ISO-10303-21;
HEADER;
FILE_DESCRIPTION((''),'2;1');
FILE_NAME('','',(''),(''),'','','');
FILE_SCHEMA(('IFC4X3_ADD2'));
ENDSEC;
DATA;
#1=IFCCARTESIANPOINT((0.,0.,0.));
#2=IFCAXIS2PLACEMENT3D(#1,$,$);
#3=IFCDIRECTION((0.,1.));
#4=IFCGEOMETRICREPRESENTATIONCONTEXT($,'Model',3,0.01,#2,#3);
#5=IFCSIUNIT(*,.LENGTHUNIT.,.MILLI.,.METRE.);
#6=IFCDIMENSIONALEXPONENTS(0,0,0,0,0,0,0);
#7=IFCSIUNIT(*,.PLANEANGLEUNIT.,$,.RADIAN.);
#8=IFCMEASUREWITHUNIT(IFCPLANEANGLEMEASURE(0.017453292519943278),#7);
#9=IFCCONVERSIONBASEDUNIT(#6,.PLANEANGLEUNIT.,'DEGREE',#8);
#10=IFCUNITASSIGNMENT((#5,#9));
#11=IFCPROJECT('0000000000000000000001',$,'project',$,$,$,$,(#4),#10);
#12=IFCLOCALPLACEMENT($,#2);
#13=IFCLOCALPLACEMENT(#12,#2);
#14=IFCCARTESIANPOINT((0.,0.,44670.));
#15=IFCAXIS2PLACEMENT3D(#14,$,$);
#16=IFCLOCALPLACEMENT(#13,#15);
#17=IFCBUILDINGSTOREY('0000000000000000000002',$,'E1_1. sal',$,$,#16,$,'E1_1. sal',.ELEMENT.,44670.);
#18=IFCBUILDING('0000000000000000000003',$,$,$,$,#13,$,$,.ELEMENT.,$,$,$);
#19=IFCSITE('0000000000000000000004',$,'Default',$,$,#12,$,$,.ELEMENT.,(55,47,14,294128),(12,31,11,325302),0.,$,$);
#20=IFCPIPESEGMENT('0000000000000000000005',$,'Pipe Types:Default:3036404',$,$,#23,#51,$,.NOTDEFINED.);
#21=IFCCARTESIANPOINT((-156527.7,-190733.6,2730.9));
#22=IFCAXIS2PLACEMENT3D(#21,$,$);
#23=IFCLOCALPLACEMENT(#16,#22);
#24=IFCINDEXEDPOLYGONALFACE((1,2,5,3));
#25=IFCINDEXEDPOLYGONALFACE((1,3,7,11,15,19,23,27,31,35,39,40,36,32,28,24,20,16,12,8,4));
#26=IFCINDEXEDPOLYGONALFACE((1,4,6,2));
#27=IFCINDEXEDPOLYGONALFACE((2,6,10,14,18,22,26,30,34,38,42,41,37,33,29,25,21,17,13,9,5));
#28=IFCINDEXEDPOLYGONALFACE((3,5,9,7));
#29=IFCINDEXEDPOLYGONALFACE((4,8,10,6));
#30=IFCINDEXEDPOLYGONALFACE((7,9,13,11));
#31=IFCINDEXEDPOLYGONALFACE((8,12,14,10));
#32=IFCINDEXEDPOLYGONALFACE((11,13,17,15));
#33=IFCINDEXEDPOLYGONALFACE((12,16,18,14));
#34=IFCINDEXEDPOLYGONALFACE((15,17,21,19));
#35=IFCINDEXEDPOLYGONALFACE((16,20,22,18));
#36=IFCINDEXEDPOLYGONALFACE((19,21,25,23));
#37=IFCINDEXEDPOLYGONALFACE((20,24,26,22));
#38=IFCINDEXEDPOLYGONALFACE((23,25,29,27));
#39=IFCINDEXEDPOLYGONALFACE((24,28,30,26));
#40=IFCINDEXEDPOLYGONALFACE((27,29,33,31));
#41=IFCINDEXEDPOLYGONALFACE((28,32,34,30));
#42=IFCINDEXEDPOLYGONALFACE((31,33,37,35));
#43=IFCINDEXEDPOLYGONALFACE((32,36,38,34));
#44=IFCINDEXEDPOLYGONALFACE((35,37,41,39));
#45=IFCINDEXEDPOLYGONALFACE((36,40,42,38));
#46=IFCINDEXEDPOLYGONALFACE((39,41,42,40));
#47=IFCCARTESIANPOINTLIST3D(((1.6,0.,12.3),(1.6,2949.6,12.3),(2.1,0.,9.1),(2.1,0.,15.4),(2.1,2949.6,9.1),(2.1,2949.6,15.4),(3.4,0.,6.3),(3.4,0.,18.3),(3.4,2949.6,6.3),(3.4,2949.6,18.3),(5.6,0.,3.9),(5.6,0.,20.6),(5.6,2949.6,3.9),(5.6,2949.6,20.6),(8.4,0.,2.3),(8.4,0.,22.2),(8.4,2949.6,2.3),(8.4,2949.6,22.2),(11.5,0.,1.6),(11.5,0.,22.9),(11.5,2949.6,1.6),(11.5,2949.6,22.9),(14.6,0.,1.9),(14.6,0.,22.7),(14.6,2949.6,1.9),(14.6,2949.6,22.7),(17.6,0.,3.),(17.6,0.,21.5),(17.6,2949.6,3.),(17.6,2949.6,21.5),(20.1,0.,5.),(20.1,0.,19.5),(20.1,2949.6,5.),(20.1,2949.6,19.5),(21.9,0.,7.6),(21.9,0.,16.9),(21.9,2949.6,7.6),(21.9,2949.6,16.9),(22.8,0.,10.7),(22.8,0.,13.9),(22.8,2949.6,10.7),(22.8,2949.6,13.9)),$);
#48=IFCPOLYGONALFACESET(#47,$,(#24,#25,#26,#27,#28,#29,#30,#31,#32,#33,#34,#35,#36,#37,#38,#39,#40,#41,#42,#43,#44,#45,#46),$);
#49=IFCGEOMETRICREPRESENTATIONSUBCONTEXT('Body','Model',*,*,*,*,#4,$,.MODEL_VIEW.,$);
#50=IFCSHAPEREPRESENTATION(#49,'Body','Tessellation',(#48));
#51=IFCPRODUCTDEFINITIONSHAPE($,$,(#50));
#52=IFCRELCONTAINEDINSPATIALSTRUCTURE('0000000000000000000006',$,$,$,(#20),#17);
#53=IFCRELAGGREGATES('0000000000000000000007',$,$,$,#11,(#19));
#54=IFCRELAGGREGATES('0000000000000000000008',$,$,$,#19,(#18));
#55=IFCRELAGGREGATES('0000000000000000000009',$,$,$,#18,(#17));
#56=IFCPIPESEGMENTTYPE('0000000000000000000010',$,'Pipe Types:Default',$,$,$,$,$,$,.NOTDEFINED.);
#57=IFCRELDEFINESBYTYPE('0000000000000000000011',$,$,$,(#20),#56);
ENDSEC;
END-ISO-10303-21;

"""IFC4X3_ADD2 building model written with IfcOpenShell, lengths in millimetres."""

from ifc_helpers import new_model, entity, si_unit, converted_unit, direction, frame, origin, origin_2d_with_axis, place, context, subcontext, project, spatial, circle, extrude, type_object, element, save


model = new_model("IFC4X3_ADD2")

# Units and contexts
model_context = context("Model", 3, precision=0.01, world=origin(), true_north=direction((0.0, 1.0)))
body_context = subcontext(model_context, "Body", "Model", "MODEL_VIEW")
ifc_project = project(units=[si_unit("LENGTHUNIT", "METRE", prefix="MILLI"), converted_unit("PLANEANGLEUNIT", "DEGREE", entity("IfcPlaneAngleMeasure", 0.017453292519943278), si_unit("PLANEANGLEUNIT", "RADIAN"), dimensions=[0, 0, 0, 0, 0, 0, 0])], contexts=[model_context])

# Site, building, storey
site_placement = place(None, origin())
site = spatial("IfcSite", under=ifc_project, at=site_placement, Name="Default", CompositionType="ELEMENT", RefLatitude=(55, 47, 14, 294128), RefLongitude=(12, 31, 11, 325302), RefElevation=0.0)
building_placement = place(site_placement, origin())
building = spatial("IfcBuilding", under=site, at=building_placement, CompositionType="ELEMENT")
storey_placement = place(building_placement, frame((0.0, 0.0, 44670.0)))
storey = spatial("IfcBuildingStorey", under=building, at=storey_placement, Name="E1_1. sal", LongName="E1_1. sal", CompositionType="ELEMENT", Elevation=44670.0)

# Pipe segment
pipe_segment_type = type_object("IfcPipeSegmentType", Name="Pipe Types:Default", PredefinedType="NOTDEFINED")
pipe_segment_1_placement = place(storey_placement, frame((-156527.7, -190733.6, 2730.9)))
element("IfcPipeSegment", 1, at=pipe_segment_1_placement, inside=storey, type_object=pipe_segment_type, Name="Pipe Types:Default:3036404", PredefinedType="NOTDEFINED", context=body_context, shape_type="SweptSolid", body=[
    extrude(circle(Radius=10.7, at=origin_2d_with_axis()), frame((12.3, 0.0, 12.3), z_axis=(0.0, 1.0, 0.0), x_axis=(-1.0, 0.0, 0.0)), (0.0, 0.0, 1.0), 2949.6),
])

save(model, "model.ifc")
